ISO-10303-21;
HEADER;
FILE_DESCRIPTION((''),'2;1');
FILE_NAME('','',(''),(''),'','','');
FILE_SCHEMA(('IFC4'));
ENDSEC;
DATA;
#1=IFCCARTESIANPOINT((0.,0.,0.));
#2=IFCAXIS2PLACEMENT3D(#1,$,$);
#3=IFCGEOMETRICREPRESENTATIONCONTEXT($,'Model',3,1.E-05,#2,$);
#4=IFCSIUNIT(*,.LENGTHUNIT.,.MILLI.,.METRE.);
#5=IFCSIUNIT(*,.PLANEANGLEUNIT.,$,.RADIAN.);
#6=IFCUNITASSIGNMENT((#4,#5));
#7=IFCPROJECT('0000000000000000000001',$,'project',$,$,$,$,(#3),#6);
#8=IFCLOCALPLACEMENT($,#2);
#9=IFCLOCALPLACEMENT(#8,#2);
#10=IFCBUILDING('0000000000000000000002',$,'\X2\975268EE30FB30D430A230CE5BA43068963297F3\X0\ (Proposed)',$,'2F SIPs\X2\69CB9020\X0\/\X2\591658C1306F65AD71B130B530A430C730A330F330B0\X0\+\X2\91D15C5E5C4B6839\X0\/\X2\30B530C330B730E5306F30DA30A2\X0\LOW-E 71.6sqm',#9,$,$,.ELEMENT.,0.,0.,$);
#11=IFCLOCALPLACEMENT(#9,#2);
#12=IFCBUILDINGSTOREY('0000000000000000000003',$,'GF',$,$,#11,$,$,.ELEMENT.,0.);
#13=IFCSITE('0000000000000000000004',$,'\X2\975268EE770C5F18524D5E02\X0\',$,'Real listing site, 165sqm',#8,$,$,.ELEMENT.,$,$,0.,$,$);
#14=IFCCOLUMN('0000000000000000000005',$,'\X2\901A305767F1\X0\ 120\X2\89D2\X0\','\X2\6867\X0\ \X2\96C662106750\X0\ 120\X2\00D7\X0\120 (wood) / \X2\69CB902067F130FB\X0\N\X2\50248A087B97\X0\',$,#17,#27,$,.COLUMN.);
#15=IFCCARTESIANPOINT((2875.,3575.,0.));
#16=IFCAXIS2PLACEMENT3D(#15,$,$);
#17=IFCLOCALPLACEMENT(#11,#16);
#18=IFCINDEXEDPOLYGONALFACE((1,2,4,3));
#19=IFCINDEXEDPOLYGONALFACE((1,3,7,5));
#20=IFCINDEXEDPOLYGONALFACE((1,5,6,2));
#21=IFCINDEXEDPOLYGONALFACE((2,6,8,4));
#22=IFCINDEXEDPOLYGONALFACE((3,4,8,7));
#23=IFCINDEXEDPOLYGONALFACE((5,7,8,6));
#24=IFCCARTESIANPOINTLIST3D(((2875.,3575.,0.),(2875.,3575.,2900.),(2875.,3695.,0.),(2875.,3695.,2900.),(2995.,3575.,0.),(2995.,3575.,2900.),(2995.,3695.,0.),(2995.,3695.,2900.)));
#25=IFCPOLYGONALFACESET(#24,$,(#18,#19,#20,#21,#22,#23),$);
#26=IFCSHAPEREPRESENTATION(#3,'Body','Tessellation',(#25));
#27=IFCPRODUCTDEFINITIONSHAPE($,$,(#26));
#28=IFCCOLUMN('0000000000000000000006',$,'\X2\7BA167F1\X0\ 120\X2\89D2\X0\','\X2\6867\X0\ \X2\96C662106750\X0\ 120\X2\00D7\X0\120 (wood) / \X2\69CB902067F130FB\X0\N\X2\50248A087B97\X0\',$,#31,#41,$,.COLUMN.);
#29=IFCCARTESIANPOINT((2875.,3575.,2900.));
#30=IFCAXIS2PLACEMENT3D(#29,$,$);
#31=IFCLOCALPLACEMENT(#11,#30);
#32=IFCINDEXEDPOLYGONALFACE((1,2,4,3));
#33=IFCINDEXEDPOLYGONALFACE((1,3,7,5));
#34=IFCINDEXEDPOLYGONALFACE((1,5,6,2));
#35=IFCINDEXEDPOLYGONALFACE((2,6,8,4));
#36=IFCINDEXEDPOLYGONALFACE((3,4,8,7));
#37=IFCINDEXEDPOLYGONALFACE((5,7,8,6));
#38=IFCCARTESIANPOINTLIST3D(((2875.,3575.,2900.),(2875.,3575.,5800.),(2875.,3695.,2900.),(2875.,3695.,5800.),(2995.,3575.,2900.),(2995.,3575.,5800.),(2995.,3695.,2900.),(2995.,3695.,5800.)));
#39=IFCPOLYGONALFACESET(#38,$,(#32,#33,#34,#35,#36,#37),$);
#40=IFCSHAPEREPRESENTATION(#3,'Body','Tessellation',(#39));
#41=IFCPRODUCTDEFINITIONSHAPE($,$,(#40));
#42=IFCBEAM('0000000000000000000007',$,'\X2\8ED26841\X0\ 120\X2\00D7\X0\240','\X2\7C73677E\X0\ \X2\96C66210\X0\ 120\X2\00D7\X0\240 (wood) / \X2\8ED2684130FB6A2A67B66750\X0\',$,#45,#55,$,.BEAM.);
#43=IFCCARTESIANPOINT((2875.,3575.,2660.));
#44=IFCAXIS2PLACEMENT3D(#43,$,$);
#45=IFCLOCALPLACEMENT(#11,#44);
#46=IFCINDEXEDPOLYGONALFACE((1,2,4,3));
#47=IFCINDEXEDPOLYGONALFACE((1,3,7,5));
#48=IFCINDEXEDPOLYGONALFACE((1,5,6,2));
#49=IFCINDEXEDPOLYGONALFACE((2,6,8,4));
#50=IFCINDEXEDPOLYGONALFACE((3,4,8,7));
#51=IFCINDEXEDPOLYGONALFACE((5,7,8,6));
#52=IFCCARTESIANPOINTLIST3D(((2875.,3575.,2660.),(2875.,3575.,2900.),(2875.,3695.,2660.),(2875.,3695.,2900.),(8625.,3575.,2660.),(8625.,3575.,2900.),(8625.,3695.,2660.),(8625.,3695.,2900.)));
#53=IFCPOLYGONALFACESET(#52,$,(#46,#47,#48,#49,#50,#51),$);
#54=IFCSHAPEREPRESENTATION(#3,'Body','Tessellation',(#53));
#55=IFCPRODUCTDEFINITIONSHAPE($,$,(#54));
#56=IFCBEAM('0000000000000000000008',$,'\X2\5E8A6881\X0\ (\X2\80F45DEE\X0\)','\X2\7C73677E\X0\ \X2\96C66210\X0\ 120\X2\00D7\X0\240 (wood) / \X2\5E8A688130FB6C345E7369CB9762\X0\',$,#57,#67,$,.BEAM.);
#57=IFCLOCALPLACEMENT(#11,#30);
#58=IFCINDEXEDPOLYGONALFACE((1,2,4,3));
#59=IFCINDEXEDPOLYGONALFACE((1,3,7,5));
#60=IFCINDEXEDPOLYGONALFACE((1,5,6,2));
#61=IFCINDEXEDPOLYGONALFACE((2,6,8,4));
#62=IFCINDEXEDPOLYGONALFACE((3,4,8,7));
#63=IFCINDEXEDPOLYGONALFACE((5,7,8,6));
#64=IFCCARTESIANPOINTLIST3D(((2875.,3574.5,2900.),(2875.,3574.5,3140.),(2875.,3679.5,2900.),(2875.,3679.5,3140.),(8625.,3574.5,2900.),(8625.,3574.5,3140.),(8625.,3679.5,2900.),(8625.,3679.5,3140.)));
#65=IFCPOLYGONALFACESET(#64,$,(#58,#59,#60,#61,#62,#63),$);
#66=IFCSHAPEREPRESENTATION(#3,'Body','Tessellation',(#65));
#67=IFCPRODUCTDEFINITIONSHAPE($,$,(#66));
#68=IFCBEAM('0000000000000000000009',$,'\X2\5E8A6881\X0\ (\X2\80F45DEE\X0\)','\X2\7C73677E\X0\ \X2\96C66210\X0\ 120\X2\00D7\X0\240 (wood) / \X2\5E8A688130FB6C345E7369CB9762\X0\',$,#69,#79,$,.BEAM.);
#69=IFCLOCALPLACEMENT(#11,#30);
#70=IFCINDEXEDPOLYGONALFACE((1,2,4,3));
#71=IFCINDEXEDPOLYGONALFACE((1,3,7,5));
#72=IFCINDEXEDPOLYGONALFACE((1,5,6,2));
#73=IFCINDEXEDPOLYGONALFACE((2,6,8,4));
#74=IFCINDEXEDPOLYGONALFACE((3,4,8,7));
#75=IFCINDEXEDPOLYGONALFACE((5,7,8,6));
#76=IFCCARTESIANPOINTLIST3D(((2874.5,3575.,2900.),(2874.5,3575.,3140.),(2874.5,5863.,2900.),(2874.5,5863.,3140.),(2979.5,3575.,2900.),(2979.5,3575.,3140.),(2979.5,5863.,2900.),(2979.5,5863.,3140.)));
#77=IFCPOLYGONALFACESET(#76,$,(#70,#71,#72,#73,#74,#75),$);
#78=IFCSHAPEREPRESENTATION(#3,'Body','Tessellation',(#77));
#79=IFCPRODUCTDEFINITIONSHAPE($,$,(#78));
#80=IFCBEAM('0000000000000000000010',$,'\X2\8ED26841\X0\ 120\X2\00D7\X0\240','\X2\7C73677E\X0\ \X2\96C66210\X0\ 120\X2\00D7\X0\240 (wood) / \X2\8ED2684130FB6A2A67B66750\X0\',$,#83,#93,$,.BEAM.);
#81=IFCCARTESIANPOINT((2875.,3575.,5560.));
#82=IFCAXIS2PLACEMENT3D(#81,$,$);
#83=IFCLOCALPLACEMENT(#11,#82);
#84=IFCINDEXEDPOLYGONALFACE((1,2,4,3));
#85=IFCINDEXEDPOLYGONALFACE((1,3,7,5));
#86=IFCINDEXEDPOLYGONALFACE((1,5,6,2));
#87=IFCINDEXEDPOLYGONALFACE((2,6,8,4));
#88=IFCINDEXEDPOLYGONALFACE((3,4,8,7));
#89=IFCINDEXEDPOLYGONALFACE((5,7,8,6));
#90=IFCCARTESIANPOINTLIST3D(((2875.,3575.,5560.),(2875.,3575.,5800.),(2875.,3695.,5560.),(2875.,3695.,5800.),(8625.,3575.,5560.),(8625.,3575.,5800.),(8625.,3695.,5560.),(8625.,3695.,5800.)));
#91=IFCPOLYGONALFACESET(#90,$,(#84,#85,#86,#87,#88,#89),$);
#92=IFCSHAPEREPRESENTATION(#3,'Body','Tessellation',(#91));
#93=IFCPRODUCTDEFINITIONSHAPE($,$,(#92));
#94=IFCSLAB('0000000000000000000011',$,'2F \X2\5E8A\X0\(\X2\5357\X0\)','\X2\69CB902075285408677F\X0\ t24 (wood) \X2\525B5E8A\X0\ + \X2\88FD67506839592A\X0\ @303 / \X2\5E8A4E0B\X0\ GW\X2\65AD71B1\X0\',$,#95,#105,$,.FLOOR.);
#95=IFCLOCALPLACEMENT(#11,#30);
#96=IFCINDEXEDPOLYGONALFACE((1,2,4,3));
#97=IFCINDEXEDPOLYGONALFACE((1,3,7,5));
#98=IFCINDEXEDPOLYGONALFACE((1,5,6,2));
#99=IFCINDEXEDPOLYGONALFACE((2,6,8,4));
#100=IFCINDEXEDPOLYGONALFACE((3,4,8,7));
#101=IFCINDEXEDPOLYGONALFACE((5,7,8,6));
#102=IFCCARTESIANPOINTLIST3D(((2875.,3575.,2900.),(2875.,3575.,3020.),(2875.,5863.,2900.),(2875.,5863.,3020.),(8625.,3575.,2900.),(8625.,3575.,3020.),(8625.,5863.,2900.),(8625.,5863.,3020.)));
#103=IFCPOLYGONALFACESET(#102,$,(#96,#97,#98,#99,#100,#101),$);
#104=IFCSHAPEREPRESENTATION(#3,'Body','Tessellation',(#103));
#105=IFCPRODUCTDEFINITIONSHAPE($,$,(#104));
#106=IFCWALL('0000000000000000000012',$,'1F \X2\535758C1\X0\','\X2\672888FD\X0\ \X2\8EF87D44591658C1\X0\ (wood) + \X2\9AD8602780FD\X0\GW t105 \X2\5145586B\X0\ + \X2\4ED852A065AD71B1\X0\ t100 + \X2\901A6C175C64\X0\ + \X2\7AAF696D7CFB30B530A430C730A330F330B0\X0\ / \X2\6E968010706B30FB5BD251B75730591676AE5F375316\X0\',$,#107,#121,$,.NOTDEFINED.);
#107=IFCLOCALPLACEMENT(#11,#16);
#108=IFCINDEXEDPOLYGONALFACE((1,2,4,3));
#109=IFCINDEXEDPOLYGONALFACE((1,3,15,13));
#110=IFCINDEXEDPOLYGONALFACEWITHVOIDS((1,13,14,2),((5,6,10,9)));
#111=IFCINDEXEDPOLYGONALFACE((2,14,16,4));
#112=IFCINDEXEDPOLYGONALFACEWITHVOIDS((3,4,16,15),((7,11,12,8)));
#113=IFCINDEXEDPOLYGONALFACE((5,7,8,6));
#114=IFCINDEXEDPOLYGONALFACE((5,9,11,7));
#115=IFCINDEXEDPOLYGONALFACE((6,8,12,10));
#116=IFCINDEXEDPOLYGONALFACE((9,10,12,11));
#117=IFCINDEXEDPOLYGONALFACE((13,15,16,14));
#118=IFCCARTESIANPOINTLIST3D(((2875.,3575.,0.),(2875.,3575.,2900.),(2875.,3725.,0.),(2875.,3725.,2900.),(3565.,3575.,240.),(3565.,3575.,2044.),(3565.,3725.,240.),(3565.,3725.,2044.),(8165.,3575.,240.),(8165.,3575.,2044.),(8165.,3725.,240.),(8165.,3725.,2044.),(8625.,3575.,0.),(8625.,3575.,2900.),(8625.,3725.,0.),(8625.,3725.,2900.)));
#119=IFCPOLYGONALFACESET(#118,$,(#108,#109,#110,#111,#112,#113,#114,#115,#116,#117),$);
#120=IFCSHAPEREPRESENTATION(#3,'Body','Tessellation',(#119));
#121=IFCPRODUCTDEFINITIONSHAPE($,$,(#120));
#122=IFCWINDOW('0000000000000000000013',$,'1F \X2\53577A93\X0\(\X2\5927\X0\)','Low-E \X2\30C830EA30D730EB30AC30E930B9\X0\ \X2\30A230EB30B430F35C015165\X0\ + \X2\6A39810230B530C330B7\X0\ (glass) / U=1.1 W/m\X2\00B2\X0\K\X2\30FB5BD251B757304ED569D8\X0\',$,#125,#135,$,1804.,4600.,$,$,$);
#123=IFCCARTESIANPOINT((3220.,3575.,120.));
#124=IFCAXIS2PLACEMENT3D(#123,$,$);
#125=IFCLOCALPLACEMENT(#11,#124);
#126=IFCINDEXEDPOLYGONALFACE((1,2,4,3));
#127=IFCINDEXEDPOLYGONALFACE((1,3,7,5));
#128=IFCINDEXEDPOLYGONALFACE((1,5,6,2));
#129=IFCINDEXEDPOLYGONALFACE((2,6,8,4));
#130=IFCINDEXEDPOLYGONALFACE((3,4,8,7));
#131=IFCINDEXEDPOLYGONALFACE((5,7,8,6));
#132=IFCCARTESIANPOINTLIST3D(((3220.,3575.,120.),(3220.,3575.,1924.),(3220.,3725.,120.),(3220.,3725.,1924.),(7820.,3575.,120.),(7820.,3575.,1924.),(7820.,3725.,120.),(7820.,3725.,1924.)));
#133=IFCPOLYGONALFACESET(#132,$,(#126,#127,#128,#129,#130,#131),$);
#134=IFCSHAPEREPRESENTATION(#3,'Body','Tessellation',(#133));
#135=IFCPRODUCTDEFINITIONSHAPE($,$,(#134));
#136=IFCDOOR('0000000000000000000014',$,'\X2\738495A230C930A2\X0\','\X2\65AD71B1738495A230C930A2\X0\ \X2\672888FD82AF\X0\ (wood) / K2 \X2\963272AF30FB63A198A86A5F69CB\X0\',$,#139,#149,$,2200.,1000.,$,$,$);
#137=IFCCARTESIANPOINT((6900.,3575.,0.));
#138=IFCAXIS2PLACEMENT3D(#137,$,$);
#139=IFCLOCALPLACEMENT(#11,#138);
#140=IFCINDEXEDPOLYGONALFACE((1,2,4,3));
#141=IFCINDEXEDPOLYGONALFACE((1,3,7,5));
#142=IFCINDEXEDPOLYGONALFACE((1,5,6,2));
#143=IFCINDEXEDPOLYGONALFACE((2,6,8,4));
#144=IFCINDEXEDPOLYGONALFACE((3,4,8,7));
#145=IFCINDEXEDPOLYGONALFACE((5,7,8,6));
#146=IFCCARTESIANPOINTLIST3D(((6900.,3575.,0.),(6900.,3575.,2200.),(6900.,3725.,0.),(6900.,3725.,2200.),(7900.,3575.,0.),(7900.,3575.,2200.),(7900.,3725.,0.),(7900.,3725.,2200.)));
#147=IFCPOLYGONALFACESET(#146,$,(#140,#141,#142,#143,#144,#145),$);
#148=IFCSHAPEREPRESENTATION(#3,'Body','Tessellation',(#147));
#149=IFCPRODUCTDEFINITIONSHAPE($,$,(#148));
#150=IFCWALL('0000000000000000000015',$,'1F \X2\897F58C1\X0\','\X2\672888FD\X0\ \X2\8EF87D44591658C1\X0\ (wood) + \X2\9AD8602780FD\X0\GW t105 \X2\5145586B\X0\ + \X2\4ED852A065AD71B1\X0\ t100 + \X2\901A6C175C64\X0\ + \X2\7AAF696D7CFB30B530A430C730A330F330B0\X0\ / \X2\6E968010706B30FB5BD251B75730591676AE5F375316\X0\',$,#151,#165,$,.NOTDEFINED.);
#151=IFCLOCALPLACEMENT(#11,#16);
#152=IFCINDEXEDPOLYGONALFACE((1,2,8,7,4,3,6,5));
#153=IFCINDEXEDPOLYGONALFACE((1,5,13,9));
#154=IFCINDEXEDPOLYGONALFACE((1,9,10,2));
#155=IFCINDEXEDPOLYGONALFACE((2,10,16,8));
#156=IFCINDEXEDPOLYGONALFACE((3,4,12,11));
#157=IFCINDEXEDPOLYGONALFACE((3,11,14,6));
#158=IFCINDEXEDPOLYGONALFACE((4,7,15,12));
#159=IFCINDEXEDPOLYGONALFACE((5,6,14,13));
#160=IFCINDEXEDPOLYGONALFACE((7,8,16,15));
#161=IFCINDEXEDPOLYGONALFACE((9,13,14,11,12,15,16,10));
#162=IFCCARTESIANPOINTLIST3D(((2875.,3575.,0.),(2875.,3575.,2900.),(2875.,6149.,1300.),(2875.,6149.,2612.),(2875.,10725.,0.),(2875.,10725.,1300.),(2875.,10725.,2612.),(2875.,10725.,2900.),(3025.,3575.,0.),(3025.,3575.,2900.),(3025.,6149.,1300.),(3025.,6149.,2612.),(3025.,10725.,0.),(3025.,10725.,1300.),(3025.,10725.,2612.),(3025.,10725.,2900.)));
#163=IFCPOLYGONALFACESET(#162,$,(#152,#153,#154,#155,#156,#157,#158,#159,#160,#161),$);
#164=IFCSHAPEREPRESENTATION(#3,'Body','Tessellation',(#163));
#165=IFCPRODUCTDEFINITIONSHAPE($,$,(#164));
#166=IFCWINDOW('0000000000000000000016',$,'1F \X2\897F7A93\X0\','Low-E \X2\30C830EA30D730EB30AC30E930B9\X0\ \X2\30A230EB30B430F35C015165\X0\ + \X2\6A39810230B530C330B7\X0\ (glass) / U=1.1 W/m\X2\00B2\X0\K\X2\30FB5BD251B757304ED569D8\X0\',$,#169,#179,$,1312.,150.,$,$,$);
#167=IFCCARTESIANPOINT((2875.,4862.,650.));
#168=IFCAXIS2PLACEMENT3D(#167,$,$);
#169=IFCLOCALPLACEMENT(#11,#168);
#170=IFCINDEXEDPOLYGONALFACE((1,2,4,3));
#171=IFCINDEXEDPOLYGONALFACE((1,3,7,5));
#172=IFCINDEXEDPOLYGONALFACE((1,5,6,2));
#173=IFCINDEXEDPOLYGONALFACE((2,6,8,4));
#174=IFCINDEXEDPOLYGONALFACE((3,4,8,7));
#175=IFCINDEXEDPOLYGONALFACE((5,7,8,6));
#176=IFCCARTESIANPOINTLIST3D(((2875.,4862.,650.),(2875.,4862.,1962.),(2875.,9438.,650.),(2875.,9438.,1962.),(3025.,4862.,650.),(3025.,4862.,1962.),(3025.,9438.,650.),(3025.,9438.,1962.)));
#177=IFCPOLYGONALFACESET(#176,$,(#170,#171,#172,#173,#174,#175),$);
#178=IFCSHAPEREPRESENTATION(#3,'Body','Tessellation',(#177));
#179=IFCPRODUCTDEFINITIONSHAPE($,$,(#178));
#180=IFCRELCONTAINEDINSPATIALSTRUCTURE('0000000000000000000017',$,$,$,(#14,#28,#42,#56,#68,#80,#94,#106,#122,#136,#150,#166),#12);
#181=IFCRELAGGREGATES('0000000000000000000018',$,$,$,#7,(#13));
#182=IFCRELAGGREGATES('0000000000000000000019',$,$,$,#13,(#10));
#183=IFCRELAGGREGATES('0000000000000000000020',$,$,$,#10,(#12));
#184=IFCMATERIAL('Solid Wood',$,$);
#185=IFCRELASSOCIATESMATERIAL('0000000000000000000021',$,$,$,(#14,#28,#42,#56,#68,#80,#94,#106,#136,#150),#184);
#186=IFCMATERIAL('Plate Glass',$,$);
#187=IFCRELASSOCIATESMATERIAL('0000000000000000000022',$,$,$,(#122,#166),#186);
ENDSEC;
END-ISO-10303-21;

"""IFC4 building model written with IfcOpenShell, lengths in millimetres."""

from ifc_helpers import new_model, si_unit, frame, frame_2d, origin, place, context, project, spatial, rectangle, extrude, material, element, fill, save


model = new_model("IFC4")

# Units and contexts
model_context = context("Model", 3, precision=1e-05, world=origin())
ifc_project = project(units=[si_unit("LENGTHUNIT", "METRE", prefix="MILLI"), si_unit("PLANEANGLEUNIT", "RADIAN")], contexts=[model_context])

# Site, building, storey
site_placement = place(None, origin())
site = spatial("IfcSite", under=ifc_project, at=site_placement, Name="青森県弘前市", ObjectType="Real listing site, 165sqm", CompositionType="ELEMENT", RefElevation=0.0)
building_placement = place(site_placement, origin())
building = spatial("IfcBuilding", under=site, at=building_placement, Name="青森・ピアノ室と防音 (Proposed)", ObjectType="2F SIPs構造/外壁は断熱サイディング+金属屋根/サッシュはペアLOW-E 71.6sqm", CompositionType="ELEMENT", ElevationOfRefHeight=0.0, ElevationOfTerrain=0.0)
storey_placement = place(building_placement, origin())
storey = spatial("IfcBuildingStorey", under=building, at=storey_placement, Name="GF", CompositionType="ELEMENT", Elevation=0.0)

# Columns
ifc_material_1 = material(Name="Solid Wood")
column_1_placement = place(storey_placement, frame((2875.0, 3575.0, 0.0)))
element("IfcColumn", 1, at=column_1_placement, inside=storey, material=ifc_material_1, Name="通し柱 120角", Description="桧 集成材 120×120 (wood) / 構造柱・N値計算", PredefinedType="COLUMN", context=model_context, shape_type="SweptSolid", body=[
    extrude(rectangle(XDim=120.0, YDim=120.0, at=frame_2d((60.0, 60.0))), frame((2875.0, 3575.0, 0.0)), (0.0, 0.0, 1.0), 2900.0),
])
column_2_placement = place(storey_placement, frame((2875.0, 3575.0, 2900.0)))
element("IfcColumn", 2, at=column_2_placement, inside=storey, material=ifc_material_1, Name="管柱 120角", Description="桧 集成材 120×120 (wood) / 構造柱・N値計算", PredefinedType="COLUMN", context=model_context, shape_type="SweptSolid", body=[
    extrude(rectangle(XDim=120.0, YDim=120.0, at=frame_2d((60.0, 60.0))), frame((2875.0, 3575.0, 2900.0)), (0.0, 0.0, 1.0), 2900.0),
])

# Beams
beam_1_placement = place(storey_placement, frame((2875.0, 3575.0, 2660.0)))
element("IfcBeam", 3, at=beam_1_placement, inside=storey, material=ifc_material_1, Name="軒桁 120×240", Description="米松 集成 120×240 (wood) / 軒桁・横架材", PredefinedType="BEAM", context=model_context, shape_type="SweptSolid", body=[
    extrude(rectangle(XDim=5750.0, YDim=120.0, at=frame_2d((2875.0, 60.0))), frame((2875.0, 3575.0, 2660.0)), (0.0, 0.0, 1.0), 240.0),
])
beam_2_placement = place(storey_placement, frame((2875.0, 3575.0, 2900.0)))
element("IfcBeam", 4, at=beam_2_placement, inside=storey, material=ifc_material_1, Name="床梁 (胴差)", Description="米松 集成 120×240 (wood) / 床梁・水平構面", PredefinedType="BEAM", context=model_context, shape_type="SweptSolid", body=[
    extrude(rectangle(XDim=5750.0, YDim=105.0, at=frame_2d((2875.0, 52.0))), frame((2875.0, 3575.0, 2900.0)), (0.0, 0.0, 1.0), 240.0),
])
beam_3_placement = place(storey_placement, frame((2875.0, 3575.0, 2900.0)))
element("IfcBeam", 5, at=beam_3_placement, inside=storey, material=ifc_material_1, Name="床梁 (胴差)", Description="米松 集成 120×240 (wood) / 床梁・水平構面", PredefinedType="BEAM", context=model_context, shape_type="SweptSolid", body=[
    extrude(rectangle(XDim=105.0, YDim=2288.0, at=frame_2d((52.0, 1144.0))), frame((2875.0, 3575.0, 2900.0)), (0.0, 0.0, 1.0), 240.0),
])
beam_4_placement = place(storey_placement, frame((2875.0, 3575.0, 5560.0)))
element("IfcBeam", 6, at=beam_4_placement, inside=storey, material=ifc_material_1, Name="軒桁 120×240", Description="米松 集成 120×240 (wood) / 軒桁・横架材", PredefinedType="BEAM", context=model_context, shape_type="SweptSolid", body=[
    extrude(rectangle(XDim=5750.0, YDim=120.0, at=frame_2d((2875.0, 60.0))), frame((2875.0, 3575.0, 5560.0)), (0.0, 0.0, 1.0), 240.0),
])

# Slab
slab_1_placement = place(storey_placement, frame((2875.0, 3575.0, 2900.0)))
element("IfcSlab", 7, at=slab_1_placement, inside=storey, material=ifc_material_1, Name="2F 床(南)", Description="構造用合板 t24 (wood) 剛床 + 製材根太 @303 / 床下 GW断熱", PredefinedType="FLOOR", context=model_context, shape_type="SweptSolid", body=[
    extrude(rectangle(XDim=5750.0, YDim=2288.0, at=frame_2d((2875.0, 1144.0))), frame((2875.0, 3575.0, 2900.0)), (0.0, 0.0, 1.0), 120.0),
])

# Wall, openings, window, door
wall_1_placement = place(storey_placement, frame((2875.0, 3575.0, 0.0)))
wall_1 = element("IfcWall", 8, at=wall_1_placement, inside=storey, material=ifc_material_1, Name="1F 南壁", Description="木製 軸組外壁 (wood) + 高性能GW t105 充填 + 付加断熱 t100 + 通気層 + 窯業系サイディング / 準耐火・寒冷地外皮強化", PredefinedType="NOTDEFINED", context=model_context, shape_type="SweptSolid", body=[
    extrude(rectangle(XDim=5750.0, YDim=150.0, at=frame_2d((2875.0, 75.0))), frame((2875.0, 3575.0, 0.0)), (0.0, 0.0, 1.0), 2900.0),
])
opening_1_placement = place(storey_placement, frame((3220.0, 3575.0, 120.0)))
opening_1 = element("IfcOpeningElement", 9, at=opening_1_placement, cuts=wall_1, PredefinedType="NOTDEFINED", context=model_context, shape_type="SweptSolid", body=[
    extrude(rectangle(XDim=4600.0, YDim=150.0, at=frame_2d((2300.0, 75.0))), frame((3220.0, 3575.0, 120.0)), (0.0, 0.0, 1.0), 1804.0),
])
opening_2_placement = place(storey_placement, frame((6900.0, 3575.0, 0.0)))
opening_2 = element("IfcOpeningElement", 10, at=opening_2_placement, cuts=wall_1, PredefinedType="NOTDEFINED", context=model_context, shape_type="SweptSolid", body=[
    extrude(rectangle(XDim=1000.0, YDim=150.0, at=frame_2d((500.0, 75.0))), frame((6900.0, 3575.0, 0.0)), (0.0, 0.0, 1.0), 2200.0),
])
ifc_material_2 = material(Name="Plate Glass")
window_1_placement = place(storey_placement, frame((3220.0, 3575.0, 120.0)))
window_1 = element("IfcWindow", 11, at=window_1_placement, inside=storey, material=ifc_material_2, Name="1F 南窓(大)", Description="Low-E トリプルガラス アルゴン封入 + 樹脂サッシ (glass) / U=1.1 W/m²K・寒冷地仕様", OverallHeight=1804.0, OverallWidth=4600.0, context=model_context, shape_type="SweptSolid", body=[
    extrude(rectangle(XDim=4600.0, YDim=150.0, at=frame_2d((2300.0, 75.0))), frame((3220.0, 3575.0, 120.0)), (0.0, 0.0, 1.0), 1804.0),
])
fill(opening_1, window_1)
door_placement = place(storey_placement, frame((6900.0, 3575.0, 0.0)))
door = element("IfcDoor", 12, at=door_placement, inside=storey, material=ifc_material_1, Name="玄関ドア", Description="断熱玄関ドア 木製芯 (wood) / K2 防犯・採風機構", OverallHeight=2200.0, OverallWidth=1000.0, context=model_context, shape_type="SweptSolid", body=[
    extrude(rectangle(XDim=1000.0, YDim=150.0, at=frame_2d((500.0, 75.0))), frame((6900.0, 3575.0, 0.0)), (0.0, 0.0, 1.0), 2200.0),
])
fill(opening_2, door)

# Wall, opening, window
wall_2_placement = place(storey_placement, frame((2875.0, 3575.0, 0.0)))
wall_2 = element("IfcWall", 13, at=wall_2_placement, inside=storey, material=ifc_material_1, Name="1F 西壁", Description="木製 軸組外壁 (wood) + 高性能GW t105 充填 + 付加断熱 t100 + 通気層 + 窯業系サイディング / 準耐火・寒冷地外皮強化", PredefinedType="NOTDEFINED", context=model_context, shape_type="SweptSolid", body=[
    extrude(rectangle(XDim=150.0, YDim=7150.0, at=frame_2d((75.0, 3575.0))), frame((2875.0, 3575.0, 0.0)), (0.0, 0.0, 1.0), 2900.0),
])
opening_3_placement = place(storey_placement, frame((2875.0, 4862.0, 650.0)))
opening_3 = element("IfcOpeningElement", 14, at=opening_3_placement, cuts=wall_2, PredefinedType="NOTDEFINED", context=model_context, shape_type="SweptSolid", body=[
    extrude(rectangle(XDim=150.0, YDim=4576.0, at=frame_2d((75.0, 2288.0))), frame((2875.0, 4862.0, 650.0)), (0.0, 0.0, 1.0), 1312.0),
])
window_2_placement = place(storey_placement, frame((2875.0, 4862.0, 650.0)))
window_2 = element("IfcWindow", 15, at=window_2_placement, inside=storey, material=ifc_material_2, Name="1F 西窓", Description="Low-E トリプルガラス アルゴン封入 + 樹脂サッシ (glass) / U=1.1 W/m²K・寒冷地仕様", OverallHeight=1312.0, OverallWidth=150.0, context=model_context, shape_type="SweptSolid", body=[
    extrude(rectangle(XDim=150.0, YDim=4576.0, at=frame_2d((75.0, 2288.0))), frame((2875.0, 4862.0, 650.0)), (0.0, 0.0, 1.0), 1312.0),
])
fill(opening_3, window_2)

save(model, "model.ifc")
